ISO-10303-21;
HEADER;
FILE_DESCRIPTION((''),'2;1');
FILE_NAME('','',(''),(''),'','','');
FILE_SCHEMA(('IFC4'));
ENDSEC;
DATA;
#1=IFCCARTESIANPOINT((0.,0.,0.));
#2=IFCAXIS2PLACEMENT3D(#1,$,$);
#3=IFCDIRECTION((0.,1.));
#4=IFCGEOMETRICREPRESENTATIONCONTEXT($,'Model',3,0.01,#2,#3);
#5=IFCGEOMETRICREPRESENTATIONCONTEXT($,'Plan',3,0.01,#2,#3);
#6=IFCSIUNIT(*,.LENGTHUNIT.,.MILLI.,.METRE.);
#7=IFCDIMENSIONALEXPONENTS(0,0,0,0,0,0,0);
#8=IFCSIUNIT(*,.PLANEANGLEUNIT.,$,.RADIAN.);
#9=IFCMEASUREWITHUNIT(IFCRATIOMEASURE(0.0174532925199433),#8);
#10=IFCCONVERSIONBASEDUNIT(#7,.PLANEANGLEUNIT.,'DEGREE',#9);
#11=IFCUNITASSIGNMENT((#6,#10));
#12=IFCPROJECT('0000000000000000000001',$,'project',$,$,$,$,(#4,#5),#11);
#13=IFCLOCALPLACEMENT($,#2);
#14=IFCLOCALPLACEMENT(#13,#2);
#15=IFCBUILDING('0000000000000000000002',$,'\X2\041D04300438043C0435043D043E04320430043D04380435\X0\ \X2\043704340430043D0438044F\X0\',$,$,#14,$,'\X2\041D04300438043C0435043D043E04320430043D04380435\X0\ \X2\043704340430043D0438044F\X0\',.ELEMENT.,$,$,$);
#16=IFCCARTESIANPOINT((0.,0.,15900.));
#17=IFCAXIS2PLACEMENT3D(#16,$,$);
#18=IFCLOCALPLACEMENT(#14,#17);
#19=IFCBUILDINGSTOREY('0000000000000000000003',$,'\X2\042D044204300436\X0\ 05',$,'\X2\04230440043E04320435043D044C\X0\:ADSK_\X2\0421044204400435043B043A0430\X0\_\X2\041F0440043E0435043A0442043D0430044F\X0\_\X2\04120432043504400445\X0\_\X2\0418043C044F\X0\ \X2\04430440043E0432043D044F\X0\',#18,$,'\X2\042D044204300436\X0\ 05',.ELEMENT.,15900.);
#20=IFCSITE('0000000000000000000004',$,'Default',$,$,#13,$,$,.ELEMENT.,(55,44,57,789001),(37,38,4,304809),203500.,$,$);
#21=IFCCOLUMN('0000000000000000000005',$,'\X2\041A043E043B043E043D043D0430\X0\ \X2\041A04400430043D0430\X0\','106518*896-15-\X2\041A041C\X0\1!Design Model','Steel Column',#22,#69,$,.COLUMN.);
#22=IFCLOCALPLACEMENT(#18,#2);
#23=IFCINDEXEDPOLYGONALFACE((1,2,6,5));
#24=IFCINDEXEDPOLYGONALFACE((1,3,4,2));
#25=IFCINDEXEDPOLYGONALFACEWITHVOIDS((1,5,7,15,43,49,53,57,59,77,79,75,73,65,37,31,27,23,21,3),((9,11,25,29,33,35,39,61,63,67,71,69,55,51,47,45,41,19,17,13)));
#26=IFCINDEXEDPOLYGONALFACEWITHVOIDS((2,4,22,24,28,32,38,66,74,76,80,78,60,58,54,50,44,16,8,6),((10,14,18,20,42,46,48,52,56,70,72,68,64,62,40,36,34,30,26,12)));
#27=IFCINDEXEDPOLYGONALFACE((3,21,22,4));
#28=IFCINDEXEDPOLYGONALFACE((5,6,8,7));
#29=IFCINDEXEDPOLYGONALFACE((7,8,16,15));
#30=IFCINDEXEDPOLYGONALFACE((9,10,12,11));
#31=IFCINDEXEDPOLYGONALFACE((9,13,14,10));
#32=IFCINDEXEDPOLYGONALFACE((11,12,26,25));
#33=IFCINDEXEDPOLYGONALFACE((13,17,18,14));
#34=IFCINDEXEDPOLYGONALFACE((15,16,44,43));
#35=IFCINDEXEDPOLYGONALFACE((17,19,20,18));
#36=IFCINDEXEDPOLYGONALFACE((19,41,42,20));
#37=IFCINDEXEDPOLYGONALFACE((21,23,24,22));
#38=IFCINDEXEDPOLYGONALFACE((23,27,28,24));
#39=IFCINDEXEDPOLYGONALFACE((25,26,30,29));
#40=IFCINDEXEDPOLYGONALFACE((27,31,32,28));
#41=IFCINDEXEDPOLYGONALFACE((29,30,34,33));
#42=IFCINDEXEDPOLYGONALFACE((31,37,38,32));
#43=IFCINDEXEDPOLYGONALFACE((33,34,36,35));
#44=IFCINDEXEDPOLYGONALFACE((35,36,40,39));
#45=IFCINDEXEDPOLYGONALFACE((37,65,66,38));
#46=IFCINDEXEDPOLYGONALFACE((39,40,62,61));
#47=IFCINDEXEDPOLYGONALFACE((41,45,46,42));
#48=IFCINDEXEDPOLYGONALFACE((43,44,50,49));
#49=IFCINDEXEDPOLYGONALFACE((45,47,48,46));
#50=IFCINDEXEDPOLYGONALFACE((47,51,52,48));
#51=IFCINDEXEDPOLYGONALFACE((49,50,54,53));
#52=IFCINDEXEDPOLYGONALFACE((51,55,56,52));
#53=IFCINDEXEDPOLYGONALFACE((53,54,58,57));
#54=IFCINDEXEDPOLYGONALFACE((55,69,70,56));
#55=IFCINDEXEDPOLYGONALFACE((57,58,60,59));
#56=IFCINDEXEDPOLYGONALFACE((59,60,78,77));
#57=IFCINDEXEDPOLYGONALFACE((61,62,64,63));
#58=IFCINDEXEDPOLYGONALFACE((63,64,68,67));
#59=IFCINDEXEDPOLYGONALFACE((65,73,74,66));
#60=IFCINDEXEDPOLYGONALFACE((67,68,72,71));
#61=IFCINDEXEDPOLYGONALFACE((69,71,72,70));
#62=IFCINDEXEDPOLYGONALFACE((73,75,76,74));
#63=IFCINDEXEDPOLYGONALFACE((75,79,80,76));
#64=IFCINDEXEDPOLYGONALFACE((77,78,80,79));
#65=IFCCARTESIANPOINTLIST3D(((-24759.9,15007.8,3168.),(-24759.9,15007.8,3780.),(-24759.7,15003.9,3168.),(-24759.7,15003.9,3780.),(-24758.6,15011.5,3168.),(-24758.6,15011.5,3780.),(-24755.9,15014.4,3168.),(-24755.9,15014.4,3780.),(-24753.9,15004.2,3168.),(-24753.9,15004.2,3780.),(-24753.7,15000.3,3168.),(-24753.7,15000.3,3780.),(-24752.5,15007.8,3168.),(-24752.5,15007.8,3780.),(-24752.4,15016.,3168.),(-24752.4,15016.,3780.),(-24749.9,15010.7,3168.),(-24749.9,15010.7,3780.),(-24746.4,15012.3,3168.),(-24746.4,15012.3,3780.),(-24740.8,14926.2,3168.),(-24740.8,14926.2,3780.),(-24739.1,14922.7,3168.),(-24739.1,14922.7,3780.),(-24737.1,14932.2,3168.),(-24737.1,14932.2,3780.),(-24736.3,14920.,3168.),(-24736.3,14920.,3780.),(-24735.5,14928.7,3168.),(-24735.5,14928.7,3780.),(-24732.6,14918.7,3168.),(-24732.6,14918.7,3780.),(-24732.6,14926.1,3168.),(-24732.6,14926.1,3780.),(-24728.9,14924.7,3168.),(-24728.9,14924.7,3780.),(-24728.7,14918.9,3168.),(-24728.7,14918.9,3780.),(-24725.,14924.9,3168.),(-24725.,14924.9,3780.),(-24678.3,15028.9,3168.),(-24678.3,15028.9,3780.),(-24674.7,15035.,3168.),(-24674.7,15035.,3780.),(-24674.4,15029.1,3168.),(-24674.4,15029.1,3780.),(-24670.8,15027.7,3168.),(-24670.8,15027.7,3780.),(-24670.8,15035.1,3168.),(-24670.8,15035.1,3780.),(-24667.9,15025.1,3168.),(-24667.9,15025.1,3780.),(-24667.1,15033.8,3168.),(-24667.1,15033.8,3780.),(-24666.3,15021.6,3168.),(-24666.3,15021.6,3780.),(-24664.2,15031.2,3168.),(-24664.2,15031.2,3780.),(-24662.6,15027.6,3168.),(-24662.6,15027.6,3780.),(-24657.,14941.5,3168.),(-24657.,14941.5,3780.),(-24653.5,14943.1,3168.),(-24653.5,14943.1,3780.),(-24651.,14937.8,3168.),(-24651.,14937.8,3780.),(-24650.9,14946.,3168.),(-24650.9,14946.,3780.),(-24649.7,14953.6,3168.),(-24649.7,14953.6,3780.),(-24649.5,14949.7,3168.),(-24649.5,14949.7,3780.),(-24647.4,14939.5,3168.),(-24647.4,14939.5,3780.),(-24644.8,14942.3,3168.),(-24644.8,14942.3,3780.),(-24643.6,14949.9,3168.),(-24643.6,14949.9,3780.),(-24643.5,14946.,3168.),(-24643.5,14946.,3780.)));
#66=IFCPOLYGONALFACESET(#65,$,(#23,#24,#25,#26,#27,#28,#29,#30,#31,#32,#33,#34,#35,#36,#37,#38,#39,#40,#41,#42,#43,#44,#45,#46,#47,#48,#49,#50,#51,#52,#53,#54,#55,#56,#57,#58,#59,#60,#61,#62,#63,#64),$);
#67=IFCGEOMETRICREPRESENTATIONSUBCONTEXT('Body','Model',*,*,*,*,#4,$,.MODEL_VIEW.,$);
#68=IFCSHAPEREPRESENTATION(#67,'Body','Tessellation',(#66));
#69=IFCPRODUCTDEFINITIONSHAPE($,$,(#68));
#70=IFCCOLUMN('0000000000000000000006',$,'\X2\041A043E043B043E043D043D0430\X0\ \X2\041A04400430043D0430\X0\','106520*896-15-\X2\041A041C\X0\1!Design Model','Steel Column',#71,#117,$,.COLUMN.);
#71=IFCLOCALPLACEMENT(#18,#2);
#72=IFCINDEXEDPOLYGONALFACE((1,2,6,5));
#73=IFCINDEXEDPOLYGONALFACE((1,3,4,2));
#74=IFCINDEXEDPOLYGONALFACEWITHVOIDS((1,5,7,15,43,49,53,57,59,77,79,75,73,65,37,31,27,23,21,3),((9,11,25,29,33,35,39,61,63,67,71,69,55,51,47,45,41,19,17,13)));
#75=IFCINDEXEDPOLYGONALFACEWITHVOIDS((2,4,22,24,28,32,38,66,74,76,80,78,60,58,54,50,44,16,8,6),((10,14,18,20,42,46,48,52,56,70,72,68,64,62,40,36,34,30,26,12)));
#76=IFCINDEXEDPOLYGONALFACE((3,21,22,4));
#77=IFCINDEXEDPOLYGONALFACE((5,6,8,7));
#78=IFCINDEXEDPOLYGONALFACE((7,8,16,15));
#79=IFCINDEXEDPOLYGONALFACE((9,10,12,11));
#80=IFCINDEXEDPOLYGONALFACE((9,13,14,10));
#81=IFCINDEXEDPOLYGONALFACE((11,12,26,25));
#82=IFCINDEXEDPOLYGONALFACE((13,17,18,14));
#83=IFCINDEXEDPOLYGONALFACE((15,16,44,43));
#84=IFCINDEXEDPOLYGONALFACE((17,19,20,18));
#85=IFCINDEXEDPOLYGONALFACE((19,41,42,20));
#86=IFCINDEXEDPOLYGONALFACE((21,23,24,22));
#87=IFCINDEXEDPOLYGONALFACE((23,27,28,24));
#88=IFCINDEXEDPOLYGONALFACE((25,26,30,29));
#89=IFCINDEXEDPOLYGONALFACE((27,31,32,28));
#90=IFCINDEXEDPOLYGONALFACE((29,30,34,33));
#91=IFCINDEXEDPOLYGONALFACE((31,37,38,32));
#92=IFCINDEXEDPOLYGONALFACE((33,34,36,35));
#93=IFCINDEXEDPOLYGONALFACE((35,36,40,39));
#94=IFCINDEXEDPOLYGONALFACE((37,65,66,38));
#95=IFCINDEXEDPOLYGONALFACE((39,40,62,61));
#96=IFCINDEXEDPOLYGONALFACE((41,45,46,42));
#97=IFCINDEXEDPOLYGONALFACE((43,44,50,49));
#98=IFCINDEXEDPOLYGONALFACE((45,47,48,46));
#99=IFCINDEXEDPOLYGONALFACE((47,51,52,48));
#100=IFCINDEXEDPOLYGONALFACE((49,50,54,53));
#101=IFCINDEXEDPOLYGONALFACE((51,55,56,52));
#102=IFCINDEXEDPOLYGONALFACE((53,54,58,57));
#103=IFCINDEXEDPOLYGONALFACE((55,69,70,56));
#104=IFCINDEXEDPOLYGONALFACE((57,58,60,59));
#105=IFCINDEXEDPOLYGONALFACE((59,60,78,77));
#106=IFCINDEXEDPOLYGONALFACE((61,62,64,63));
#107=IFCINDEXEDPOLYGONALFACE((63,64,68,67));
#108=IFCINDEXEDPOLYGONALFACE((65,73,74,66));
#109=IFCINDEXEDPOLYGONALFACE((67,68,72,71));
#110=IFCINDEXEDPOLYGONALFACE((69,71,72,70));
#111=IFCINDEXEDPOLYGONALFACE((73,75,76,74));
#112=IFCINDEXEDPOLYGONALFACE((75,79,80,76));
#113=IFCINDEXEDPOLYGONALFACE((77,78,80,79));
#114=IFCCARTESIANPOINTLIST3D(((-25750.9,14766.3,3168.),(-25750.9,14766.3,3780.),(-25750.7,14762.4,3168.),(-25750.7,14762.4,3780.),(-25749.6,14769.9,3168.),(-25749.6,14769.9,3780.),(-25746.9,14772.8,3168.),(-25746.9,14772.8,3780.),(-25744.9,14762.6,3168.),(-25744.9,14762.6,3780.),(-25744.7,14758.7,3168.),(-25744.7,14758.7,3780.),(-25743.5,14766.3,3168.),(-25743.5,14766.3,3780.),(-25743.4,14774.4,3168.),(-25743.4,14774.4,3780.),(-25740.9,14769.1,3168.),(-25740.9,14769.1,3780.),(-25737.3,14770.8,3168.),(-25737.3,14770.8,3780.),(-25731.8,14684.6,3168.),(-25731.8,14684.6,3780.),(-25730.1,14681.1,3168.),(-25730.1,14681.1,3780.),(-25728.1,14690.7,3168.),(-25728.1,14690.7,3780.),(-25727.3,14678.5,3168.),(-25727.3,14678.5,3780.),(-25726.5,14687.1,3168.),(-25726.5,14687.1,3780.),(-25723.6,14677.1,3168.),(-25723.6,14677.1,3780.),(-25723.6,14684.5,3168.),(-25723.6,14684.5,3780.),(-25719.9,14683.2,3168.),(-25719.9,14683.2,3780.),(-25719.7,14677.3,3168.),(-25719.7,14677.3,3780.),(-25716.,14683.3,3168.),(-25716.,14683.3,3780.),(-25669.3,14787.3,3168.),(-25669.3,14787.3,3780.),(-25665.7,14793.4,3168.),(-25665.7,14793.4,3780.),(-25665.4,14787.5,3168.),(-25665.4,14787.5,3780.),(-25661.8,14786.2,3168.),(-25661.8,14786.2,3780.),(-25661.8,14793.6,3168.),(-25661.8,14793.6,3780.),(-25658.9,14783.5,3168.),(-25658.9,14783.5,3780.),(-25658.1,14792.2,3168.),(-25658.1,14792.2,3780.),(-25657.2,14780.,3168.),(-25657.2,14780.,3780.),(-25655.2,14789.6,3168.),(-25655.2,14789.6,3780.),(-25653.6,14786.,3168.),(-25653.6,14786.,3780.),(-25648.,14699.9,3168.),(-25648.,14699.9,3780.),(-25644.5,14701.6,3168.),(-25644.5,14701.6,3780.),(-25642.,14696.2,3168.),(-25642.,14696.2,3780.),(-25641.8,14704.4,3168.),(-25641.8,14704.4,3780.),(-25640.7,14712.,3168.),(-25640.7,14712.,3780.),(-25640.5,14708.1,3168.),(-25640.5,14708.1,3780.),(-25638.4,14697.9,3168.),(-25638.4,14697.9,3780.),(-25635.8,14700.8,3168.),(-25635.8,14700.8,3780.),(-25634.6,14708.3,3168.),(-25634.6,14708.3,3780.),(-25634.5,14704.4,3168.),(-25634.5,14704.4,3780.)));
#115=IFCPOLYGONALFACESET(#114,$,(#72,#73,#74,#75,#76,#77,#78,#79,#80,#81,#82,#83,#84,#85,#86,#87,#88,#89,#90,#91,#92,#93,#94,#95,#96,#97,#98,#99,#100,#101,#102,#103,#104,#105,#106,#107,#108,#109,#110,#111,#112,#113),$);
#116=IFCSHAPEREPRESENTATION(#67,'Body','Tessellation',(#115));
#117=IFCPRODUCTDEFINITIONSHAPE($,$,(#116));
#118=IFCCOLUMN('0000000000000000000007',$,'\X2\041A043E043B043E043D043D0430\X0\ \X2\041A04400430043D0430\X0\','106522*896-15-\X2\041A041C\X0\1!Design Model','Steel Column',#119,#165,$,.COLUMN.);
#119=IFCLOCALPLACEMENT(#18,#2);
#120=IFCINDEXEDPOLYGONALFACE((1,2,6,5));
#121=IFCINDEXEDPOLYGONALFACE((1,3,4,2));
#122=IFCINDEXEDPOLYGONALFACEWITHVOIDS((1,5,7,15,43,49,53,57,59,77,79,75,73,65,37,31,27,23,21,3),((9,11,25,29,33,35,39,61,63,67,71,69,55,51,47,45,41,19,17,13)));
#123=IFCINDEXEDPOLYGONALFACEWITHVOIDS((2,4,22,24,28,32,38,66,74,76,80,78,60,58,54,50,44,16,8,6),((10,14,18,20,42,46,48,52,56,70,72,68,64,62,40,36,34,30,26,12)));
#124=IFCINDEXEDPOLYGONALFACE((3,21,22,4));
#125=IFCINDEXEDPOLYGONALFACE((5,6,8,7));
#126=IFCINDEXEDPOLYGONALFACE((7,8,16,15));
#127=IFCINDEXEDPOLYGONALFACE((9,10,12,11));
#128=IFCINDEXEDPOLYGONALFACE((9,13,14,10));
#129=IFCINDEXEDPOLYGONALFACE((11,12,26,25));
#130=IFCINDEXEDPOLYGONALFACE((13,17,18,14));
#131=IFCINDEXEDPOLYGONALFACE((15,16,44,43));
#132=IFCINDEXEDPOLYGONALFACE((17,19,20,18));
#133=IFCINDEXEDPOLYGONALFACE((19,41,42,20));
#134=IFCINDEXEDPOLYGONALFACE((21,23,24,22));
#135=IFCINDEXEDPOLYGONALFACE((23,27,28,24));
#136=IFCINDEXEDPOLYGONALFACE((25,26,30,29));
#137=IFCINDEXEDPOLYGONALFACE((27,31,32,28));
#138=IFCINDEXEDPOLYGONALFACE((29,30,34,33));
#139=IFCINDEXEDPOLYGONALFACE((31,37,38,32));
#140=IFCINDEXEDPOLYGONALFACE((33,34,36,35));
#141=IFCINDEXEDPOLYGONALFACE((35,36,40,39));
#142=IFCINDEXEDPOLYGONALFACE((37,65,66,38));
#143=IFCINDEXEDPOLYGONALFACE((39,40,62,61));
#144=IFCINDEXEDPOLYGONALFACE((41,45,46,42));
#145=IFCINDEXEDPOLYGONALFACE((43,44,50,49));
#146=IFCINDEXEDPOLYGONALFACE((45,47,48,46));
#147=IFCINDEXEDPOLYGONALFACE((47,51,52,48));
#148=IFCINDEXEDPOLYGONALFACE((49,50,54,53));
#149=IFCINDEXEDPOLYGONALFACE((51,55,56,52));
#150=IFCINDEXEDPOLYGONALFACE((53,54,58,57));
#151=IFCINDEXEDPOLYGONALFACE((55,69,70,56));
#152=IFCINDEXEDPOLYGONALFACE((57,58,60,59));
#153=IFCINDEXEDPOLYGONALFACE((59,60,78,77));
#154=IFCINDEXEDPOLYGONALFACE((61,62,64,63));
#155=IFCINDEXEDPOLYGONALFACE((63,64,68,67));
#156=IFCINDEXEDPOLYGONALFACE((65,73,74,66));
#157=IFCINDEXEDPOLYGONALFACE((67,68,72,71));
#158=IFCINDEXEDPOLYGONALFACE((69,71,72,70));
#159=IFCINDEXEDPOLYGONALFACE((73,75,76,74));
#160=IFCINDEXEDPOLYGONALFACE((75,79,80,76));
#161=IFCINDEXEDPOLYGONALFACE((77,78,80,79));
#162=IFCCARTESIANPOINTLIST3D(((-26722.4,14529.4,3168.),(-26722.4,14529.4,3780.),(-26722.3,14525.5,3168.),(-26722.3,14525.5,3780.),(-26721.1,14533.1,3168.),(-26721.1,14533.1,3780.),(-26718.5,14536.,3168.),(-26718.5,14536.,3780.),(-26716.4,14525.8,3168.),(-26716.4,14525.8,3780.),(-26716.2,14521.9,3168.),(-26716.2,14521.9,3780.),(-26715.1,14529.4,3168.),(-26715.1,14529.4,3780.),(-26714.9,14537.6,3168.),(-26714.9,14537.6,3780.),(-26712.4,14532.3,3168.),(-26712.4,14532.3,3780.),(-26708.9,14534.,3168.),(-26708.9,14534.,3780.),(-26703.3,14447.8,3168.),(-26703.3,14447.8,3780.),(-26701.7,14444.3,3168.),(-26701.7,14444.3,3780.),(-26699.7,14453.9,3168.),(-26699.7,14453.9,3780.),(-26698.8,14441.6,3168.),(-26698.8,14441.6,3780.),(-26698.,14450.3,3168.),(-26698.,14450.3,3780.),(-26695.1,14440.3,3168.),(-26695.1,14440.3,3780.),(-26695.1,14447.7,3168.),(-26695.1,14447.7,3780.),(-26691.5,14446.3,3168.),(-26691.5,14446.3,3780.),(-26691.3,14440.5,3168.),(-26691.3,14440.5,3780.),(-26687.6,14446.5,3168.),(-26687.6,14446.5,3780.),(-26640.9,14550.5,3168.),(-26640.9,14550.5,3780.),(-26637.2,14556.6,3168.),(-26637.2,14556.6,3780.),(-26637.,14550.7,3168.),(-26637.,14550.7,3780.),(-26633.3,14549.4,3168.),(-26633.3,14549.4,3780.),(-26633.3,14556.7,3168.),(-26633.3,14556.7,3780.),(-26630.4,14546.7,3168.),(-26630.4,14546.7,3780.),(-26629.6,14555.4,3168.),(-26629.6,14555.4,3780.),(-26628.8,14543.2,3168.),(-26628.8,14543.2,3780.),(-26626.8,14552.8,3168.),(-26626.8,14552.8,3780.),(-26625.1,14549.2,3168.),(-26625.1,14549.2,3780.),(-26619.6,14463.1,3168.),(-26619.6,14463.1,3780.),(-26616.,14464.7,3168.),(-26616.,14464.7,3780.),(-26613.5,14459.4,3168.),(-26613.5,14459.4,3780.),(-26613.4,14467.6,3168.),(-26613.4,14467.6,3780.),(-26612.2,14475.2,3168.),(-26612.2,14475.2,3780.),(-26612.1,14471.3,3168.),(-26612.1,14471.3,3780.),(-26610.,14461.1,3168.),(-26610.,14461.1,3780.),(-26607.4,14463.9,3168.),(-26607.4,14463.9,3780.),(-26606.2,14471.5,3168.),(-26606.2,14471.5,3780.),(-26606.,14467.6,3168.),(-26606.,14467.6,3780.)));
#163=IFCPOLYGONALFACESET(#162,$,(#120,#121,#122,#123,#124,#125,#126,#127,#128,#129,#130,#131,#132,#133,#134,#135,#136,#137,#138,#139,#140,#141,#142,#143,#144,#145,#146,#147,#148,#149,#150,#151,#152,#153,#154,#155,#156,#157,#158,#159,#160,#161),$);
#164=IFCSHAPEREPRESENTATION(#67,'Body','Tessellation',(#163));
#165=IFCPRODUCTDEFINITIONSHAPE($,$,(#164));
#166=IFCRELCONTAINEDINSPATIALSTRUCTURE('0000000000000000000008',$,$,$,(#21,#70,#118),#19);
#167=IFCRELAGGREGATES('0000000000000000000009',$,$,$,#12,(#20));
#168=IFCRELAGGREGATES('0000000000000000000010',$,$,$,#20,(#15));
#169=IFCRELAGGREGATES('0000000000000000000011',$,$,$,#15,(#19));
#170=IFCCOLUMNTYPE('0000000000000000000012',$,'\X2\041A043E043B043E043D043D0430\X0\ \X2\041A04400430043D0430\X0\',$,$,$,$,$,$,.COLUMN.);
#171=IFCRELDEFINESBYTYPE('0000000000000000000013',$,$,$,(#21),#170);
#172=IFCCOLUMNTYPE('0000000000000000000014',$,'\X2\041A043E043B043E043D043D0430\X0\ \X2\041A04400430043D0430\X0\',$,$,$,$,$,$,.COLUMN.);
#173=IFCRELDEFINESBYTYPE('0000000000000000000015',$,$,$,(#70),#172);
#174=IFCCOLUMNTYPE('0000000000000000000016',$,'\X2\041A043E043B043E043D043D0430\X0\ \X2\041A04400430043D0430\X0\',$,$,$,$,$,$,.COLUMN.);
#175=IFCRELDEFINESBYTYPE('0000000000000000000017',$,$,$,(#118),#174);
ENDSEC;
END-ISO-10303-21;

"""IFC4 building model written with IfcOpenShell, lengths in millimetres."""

from ifc_helpers import new_model, entity, si_unit, converted_unit, direction, frame, origin, place, context, subcontext, project, spatial, indexed_curve, outline, extrude, type_object, element, save


model = new_model("IFC4")

# Units and contexts
model_context = context("Model", 3, precision=0.01, world=origin(), true_north=direction((0.0, 1.0)))
plan_context = context("Plan", 3, precision=0.01, world=origin(), true_north=direction((0.0, 1.0)))
body_context = subcontext(model_context, "Body", "Model", "MODEL_VIEW")
ifc_project = project(units=[si_unit("LENGTHUNIT", "METRE", prefix="MILLI"), converted_unit("PLANEANGLEUNIT", "DEGREE", entity("IfcRatioMeasure", 0.0174532925199433), si_unit("PLANEANGLEUNIT", "RADIAN"), dimensions=[0, 0, 0, 0, 0, 0, 0])], contexts=[model_context, plan_context])

# Site, building, storey
site_placement = place(None, origin())
site = spatial("IfcSite", under=ifc_project, at=site_placement, Name="Default", CompositionType="ELEMENT", RefLatitude=(55, 44, 57, 789001), RefLongitude=(37, 38, 4, 304809), RefElevation=203500.0)
building_placement = place(site_placement, origin())
building = spatial("IfcBuilding", under=site, at=building_placement, Name="Наименование здания", LongName="Наименование здания", CompositionType="ELEMENT")
storey_placement = place(building_placement, frame((0.0, 0.0, 15900.0)))
storey = spatial("IfcBuildingStorey", under=building, at=storey_placement, Name="Этаж 05", ObjectType="Уровень:ADSK_Стрелка_Проектная_Вверх_Имя уровня", LongName="Этаж 05", CompositionType="ELEMENT", Elevation=15900.0)

# Columns
placement = place(storey_placement, origin())
column_type_1 = type_object("IfcColumnType", Name="Колонна Крана", PredefinedType="COLUMN")
element("IfcColumn", 1, at=placement, inside=storey, type_object=column_type_1, Name="Колонна Крана", Description="106518*896-15-КМ1!Design Model", ObjectType="Steel Column", PredefinedType="COLUMN", context=body_context, shape_type="SweptSolid", body=[
    extrude(outline(indexed_curve([(29.5, -56.8), (33.4, -56.8), (37.0, -55.3), (39.7, -52.6), (41.2, -49.0), (56.8, 29.5), (56.8, 33.4), (55.3, 37.0), (52.6, 39.7), (49.0, 41.2), (-29.5, 56.8), (-33.4, 56.8), (-37.0, 55.3), (-39.7, 52.6), (-41.2, 49.0), (-56.8, -29.5), (-56.8, -33.4), (-55.3, -37.0), (-52.6, -39.7), (-49.0, -41.2), (29.5, -56.8)], self_intersect=False), holes=[indexed_curve([(-43.1, -37.3), (-46.7, -35.8), (-49.5, -33.1), (-51.0, -29.5), (-51.0, -25.5), (-37.3, 43.1), (-35.8, 46.7), (-33.1, 49.5), (-29.5, 51.0), (-25.5, 51.0), (43.1, 37.3), (46.7, 35.8), (49.5, 33.1), (51.0, 29.5), (51.0, 25.5), (37.3, -43.1), (35.8, -46.7), (33.1, -49.5), (29.5, -51.0), (25.5, -51.0), (-43.1, -37.3)], self_intersect=False)]), frame((-24701.7, 14976.9, 3168.0), z_axis=(0.0, 0.0, 1.0), x_axis=(0.906681, 0.421816, 0.0)), (0.0, 0.0, 1.0), 612.0),
])
column_type_2 = type_object("IfcColumnType", Name="Колонна Крана", PredefinedType="COLUMN")
element("IfcColumn", 2, at=placement, inside=storey, type_object=column_type_2, Name="Колонна Крана", Description="106520*896-15-КМ1!Design Model", ObjectType="Steel Column", PredefinedType="COLUMN", context=body_context, shape_type="SweptSolid", body=[
    extrude(outline(indexed_curve([(29.5, -56.8), (33.4, -56.8), (37.0, -55.3), (39.7, -52.6), (41.2, -49.0), (56.8, 29.5), (56.8, 33.4), (55.3, 37.0), (52.6, 39.7), (49.0, 41.2), (-29.5, 56.8), (-33.4, 56.8), (-37.0, 55.3), (-39.7, 52.6), (-41.2, 49.0), (-56.8, -29.5), (-56.8, -33.4), (-55.3, -37.0), (-52.6, -39.7), (-49.0, -41.2), (29.5, -56.8)], self_intersect=False), holes=[indexed_curve([(-43.1, -37.3), (-46.7, -35.8), (-49.5, -33.1), (-51.0, -29.5), (-51.0, -25.5), (-37.3, 43.1), (-35.8, 46.7), (-33.1, 49.5), (-29.5, 51.0), (-25.5, 51.0), (43.1, 37.3), (46.7, 35.8), (49.5, 33.1), (51.0, 29.5), (51.0, 25.5), (37.3, -43.1), (35.8, -46.7), (33.1, -49.5), (29.5, -51.0), (25.5, -51.0), (-43.1, -37.3)], self_intersect=False)]), frame((-25692.7, 14735.3, 3168.0), z_axis=(0.0, 0.0, 1.0), x_axis=(0.906681, 0.421816, 0.0)), (0.0, 0.0, 1.0), 612.0),
])
column_type_3 = type_object("IfcColumnType", Name="Колонна Крана", PredefinedType="COLUMN")
element("IfcColumn", 3, at=placement, inside=storey, type_object=column_type_3, Name="Колонна Крана", Description="106522*896-15-КМ1!Design Model", ObjectType="Steel Column", PredefinedType="COLUMN", context=body_context, shape_type="SweptSolid", body=[
    extrude(outline(indexed_curve([(29.5, -56.8), (33.4, -56.8), (37.0, -55.3), (39.7, -52.6), (41.2, -49.0), (56.8, 29.5), (56.8, 33.4), (55.3, 37.0), (52.6, 39.7), (49.0, 41.2), (-29.5, 56.8), (-33.4, 56.8), (-37.0, 55.3), (-39.7, 52.6), (-41.2, 49.0), (-56.8, -29.5), (-56.8, -33.4), (-55.3, -37.0), (-52.6, -39.7), (-49.0, -41.2), (29.5, -56.8)], self_intersect=False), holes=[indexed_curve([(-43.1, -37.3), (-46.7, -35.8), (-49.5, -33.1), (-51.0, -29.5), (-51.0, -25.5), (-37.3, 43.1), (-35.8, 46.7), (-33.1, 49.5), (-29.5, 51.0), (-25.5, 51.0), (43.1, 37.3), (46.7, 35.8), (49.5, 33.1), (51.0, 29.5), (51.0, 25.5), (37.3, -43.1), (35.8, -46.7), (33.1, -49.5), (29.5, -51.0), (25.5, -51.0), (-43.1, -37.3)], self_intersect=False)]), frame((-26664.2, 14498.5, 3168.0), z_axis=(0.0, 0.0, 1.0), x_axis=(0.906681, 0.421816, 0.0)), (0.0, 0.0, 1.0), 612.0),
])

save(model, "model.ifc")
